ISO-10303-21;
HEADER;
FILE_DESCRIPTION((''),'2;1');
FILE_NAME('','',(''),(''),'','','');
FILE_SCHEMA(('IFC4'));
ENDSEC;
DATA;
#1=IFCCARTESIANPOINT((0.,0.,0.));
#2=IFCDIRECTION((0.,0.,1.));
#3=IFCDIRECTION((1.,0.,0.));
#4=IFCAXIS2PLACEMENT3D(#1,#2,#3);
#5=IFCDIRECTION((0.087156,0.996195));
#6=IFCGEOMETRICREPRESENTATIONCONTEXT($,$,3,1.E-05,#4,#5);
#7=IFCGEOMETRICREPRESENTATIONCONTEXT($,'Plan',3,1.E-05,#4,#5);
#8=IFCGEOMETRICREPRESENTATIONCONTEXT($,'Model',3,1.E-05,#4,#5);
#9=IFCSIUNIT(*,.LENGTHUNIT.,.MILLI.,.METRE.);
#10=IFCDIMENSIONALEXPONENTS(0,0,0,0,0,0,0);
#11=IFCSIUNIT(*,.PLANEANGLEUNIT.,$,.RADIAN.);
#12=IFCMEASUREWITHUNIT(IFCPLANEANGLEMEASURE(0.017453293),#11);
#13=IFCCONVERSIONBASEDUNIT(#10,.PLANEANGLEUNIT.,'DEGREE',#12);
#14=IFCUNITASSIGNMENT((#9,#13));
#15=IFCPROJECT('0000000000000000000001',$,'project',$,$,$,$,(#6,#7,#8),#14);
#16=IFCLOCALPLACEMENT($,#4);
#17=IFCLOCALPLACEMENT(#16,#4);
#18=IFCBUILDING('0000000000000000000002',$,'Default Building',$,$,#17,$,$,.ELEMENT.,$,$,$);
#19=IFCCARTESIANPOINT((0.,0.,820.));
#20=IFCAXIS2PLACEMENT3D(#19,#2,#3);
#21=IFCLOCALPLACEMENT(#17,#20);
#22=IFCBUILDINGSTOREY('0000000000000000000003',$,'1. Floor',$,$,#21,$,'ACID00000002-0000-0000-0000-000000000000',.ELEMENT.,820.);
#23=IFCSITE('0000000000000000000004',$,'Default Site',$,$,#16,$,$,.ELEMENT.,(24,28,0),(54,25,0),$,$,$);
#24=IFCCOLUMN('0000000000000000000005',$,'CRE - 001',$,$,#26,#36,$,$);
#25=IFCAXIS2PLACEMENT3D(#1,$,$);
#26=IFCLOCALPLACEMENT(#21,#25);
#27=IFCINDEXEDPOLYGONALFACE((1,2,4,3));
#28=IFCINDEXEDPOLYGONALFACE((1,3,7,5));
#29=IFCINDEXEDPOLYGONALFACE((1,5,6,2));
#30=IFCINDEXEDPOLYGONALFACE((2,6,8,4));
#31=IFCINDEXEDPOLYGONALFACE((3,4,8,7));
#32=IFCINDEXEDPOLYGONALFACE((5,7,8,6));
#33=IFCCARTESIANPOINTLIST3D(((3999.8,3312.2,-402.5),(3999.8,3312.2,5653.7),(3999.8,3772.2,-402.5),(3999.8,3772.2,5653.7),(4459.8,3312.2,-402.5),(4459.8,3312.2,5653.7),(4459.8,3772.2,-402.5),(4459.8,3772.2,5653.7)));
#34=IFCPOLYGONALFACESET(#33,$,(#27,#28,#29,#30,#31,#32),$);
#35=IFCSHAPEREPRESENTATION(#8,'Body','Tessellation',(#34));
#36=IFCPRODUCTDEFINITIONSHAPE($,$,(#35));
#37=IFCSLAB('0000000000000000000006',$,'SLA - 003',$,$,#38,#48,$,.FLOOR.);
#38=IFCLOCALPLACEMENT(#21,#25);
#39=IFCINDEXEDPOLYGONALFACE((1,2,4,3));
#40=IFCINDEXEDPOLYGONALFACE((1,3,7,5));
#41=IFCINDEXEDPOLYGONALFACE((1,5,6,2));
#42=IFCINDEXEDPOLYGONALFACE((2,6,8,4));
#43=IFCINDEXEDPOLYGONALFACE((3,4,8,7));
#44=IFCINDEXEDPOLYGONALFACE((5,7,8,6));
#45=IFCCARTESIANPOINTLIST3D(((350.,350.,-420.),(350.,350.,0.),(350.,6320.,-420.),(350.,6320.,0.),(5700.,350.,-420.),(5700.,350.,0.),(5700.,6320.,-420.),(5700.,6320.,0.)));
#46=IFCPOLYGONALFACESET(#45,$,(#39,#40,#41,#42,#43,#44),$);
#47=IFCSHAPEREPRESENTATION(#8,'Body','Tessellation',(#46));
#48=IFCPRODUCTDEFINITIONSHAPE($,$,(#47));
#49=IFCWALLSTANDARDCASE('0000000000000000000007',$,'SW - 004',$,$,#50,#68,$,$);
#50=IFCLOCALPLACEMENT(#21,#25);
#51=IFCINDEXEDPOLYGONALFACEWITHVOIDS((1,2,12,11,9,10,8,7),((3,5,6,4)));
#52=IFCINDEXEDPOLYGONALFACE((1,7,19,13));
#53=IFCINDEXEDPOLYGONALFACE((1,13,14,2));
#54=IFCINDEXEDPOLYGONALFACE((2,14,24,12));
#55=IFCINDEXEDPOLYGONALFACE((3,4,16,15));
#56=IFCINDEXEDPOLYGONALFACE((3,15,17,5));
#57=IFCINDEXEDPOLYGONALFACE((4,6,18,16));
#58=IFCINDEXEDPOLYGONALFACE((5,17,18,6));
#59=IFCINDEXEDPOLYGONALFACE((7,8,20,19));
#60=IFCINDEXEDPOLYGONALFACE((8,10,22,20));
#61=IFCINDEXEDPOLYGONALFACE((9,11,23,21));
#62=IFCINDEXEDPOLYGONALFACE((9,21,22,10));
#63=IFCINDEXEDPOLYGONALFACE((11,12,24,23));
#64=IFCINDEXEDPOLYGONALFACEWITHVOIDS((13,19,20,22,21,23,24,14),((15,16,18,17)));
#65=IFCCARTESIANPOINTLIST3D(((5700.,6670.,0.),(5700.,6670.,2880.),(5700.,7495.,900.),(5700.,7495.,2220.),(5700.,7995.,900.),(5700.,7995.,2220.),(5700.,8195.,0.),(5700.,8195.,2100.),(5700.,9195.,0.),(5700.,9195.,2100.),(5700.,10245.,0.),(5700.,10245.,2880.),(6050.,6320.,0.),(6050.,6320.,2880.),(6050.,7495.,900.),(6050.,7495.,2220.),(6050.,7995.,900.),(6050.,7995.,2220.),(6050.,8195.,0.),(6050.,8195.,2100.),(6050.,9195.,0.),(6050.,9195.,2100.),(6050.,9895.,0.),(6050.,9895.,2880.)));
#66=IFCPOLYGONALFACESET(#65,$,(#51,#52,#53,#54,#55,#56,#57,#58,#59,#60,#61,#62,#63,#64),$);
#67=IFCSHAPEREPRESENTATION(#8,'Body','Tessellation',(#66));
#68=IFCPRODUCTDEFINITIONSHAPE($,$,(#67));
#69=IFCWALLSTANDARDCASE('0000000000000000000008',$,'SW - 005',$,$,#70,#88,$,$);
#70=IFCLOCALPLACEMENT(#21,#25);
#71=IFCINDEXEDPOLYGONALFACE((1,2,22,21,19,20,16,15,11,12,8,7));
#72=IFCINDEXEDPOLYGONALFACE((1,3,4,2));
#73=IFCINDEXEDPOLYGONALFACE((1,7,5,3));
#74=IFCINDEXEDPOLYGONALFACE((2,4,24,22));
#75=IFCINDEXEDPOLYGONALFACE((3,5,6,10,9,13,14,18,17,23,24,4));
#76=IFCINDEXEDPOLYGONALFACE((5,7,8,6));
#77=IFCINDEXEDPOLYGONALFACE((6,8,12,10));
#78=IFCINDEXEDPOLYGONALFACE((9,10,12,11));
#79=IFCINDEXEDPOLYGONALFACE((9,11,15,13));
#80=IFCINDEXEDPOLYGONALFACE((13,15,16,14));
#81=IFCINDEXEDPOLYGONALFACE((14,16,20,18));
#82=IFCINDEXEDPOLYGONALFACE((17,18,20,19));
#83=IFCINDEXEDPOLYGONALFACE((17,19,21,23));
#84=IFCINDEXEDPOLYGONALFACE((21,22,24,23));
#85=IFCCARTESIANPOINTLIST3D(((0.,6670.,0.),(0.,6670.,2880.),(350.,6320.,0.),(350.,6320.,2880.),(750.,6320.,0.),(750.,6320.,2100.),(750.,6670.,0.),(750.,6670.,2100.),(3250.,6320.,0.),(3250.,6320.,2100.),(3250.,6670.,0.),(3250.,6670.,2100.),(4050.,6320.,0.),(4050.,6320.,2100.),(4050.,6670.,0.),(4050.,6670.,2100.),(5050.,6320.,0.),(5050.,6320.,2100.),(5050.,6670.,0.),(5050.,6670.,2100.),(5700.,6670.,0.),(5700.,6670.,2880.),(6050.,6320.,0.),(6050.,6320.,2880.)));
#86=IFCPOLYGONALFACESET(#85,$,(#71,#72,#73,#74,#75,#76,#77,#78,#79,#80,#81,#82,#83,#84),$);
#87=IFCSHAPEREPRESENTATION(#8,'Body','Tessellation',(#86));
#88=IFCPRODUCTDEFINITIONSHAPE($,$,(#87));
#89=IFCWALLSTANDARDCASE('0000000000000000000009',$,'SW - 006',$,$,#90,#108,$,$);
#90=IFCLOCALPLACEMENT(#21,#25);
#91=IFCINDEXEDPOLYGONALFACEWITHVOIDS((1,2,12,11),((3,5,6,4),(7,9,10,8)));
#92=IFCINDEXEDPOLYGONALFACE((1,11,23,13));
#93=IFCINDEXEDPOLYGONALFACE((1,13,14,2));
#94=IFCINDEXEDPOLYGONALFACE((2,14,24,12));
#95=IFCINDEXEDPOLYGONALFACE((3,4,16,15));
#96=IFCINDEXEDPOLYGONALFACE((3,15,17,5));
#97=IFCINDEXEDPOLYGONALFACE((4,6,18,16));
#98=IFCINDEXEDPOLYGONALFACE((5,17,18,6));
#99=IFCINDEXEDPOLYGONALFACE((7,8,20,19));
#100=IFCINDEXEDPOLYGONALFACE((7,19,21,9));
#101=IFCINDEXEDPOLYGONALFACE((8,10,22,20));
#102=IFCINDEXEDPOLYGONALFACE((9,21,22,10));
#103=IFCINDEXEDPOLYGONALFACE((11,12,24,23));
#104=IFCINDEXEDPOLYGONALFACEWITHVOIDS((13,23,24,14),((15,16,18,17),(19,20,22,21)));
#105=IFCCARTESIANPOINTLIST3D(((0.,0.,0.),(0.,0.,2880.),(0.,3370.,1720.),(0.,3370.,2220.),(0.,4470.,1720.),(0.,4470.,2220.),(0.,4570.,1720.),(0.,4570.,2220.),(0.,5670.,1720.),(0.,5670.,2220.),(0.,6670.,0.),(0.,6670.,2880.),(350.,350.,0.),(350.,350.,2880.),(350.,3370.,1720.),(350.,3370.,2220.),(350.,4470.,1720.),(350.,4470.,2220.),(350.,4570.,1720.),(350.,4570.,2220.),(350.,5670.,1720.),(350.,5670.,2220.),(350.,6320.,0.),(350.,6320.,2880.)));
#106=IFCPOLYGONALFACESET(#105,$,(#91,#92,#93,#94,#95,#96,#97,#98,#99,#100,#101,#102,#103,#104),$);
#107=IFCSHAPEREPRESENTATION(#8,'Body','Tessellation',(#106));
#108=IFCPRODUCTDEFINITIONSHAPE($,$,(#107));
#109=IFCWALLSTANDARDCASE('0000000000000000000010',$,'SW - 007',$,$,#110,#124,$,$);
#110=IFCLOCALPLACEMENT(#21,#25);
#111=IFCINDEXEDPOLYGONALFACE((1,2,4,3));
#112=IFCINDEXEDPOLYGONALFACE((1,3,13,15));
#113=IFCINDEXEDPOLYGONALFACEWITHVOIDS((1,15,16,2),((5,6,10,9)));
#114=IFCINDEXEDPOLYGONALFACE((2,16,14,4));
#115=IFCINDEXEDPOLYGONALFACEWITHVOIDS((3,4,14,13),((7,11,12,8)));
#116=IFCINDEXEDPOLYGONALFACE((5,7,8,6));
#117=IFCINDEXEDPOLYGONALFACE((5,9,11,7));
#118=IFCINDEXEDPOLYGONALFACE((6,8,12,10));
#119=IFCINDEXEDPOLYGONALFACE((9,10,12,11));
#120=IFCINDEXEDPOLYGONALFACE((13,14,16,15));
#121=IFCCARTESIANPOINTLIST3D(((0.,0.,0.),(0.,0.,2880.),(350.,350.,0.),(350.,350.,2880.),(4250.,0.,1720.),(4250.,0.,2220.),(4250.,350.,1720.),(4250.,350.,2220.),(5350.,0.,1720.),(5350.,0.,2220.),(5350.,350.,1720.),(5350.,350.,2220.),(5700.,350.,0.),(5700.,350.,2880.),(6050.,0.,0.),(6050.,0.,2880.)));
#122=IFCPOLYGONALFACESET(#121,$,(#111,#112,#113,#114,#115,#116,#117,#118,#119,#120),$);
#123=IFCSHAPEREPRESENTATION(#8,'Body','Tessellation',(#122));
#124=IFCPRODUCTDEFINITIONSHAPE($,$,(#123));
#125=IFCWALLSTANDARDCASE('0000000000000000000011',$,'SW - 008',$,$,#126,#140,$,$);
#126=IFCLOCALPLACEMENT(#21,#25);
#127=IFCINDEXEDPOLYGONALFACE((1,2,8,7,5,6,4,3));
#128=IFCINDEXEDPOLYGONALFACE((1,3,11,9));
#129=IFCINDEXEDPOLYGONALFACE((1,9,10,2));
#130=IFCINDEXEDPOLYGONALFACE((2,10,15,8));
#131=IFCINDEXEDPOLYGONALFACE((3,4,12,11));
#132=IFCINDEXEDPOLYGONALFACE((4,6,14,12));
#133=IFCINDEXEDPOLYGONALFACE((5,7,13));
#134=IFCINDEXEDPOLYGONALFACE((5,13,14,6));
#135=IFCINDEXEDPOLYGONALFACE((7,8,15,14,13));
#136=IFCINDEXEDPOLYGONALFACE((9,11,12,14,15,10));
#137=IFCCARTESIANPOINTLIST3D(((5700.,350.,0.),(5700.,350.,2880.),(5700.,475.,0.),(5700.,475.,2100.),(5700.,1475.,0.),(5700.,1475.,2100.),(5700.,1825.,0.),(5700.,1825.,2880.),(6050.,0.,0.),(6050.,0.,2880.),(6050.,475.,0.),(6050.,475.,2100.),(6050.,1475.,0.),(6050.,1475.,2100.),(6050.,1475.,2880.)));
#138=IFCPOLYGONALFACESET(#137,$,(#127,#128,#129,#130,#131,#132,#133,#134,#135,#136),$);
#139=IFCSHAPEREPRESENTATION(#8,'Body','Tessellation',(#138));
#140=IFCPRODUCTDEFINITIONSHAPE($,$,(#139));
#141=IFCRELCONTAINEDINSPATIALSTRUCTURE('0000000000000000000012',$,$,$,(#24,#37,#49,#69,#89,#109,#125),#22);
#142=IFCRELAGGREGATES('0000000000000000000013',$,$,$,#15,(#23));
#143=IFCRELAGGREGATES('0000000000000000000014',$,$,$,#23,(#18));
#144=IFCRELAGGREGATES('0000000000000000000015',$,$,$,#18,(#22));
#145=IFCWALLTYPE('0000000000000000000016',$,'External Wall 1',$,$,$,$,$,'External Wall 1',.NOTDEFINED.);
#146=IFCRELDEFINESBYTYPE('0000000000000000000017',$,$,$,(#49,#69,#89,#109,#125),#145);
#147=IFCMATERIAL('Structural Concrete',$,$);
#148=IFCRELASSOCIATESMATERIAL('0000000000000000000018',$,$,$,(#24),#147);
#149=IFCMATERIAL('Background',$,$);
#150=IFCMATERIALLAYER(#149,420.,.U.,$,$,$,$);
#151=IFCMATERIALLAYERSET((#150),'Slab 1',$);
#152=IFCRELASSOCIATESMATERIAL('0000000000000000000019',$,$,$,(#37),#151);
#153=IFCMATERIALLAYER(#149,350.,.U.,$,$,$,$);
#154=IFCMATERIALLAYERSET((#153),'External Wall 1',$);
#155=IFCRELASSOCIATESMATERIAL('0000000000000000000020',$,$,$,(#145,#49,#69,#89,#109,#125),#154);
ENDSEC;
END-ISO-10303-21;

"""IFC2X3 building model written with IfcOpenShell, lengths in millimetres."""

from ifc_helpers import new_model, entity, si_unit, converted_unit, direction, frame, frame_2d, origin_with_axes, origin_2d_with_axis, place, context, project, spatial, polyline, rectangle, outline, extrude, material, layer, layer_set, layer_usage, type_object, element, save


model = new_model("IFC2X3")

# Units and contexts
context_of_model = context(None, 3, precision=1e-05, world=origin_with_axes(), true_north=direction((0.087156, 0.996195)))
plan_context = context("Plan", 3, precision=1e-05, world=origin_with_axes(), true_north=direction((0.087156, 0.996195)))
model_context = context("Model", 3, precision=1e-05, world=origin_with_axes(), true_north=direction((0.087156, 0.996195)))
ifc_project = project(units=[si_unit("LENGTHUNIT", "METRE", prefix="MILLI"), converted_unit("PLANEANGLEUNIT", "DEGREE", entity("IfcPlaneAngleMeasure", 0.017453293), si_unit("PLANEANGLEUNIT", "RADIAN"), dimensions=[0, 0, 0, 0, 0, 0, 0])], contexts=[context_of_model, plan_context, model_context])

# Site, building, storey
site_placement = place(None, origin_with_axes())
site = spatial("IfcSite", under=ifc_project, at=site_placement, Name="Default Site", CompositionType="ELEMENT", RefLatitude=(24, 28, 0), RefLongitude=(54, 25, 0))
building_placement = place(site_placement, origin_with_axes())
building = spatial("IfcBuilding", under=site, at=building_placement, Name="Default Building", CompositionType="ELEMENT")
storey_placement = place(building_placement, frame((0.0, 0.0, 820.0), z_axis=(0.0, 0.0, 1.0), x_axis=(1.0, 0.0, 0.0)))
storey = spatial("IfcBuildingStorey", under=building, at=storey_placement, Name="1. Floor", LongName="ACID00000002-0000-0000-0000-000000000000", CompositionType="ELEMENT", Elevation=820.0)

# Column
ifc_material_1 = material(Name="Structural Concrete")
column_placement = place(storey_placement, frame((4229.8, 3542.2, -402.5), z_axis=(0.0, 0.0, 1.0), x_axis=(-1.0, 0.0, 0.0)))
element("IfcColumn", 1, at=column_placement, inside=storey, material=ifc_material_1, Name="CRE - 001", context=model_context, shape_type="SweptSolid", body=[
    extrude(rectangle(XDim=460.0, YDim=460.0, at=origin_2d_with_axis()), origin_with_axes(), (0.0, 0.0, 1.0), 6056.2),
])

# Slab
ifc_material_2 = material(Name="Background")
ifc_layer_1 = layer(ifc_material_2, 420.0, ventilated="UNKNOWN")
ifc_layer_set_1 = layer_set([ifc_layer_1], Name="Slab 1")
ifc_layer_usage_1 = layer_usage(ifc_layer_set_1, "AXIS3", "NEGATIVE", 420.0)
slab_placement = place(storey_placement, frame((350.0, 6320.0, -420.0), z_axis=(0.0, 0.0, 1.0), x_axis=(0.0, -1.0, 0.0)))
element("IfcSlab", 2, at=slab_placement, inside=storey, material=ifc_layer_usage_1, Name="SLA - 003", PredefinedType="FLOOR", context=model_context, shape_type="SweptSolid", body=[
    extrude(outline(polyline([(0.0, 0.0), (5970.0, 0.0), (5970.0, 5350.0), (0.0, 5350.0), (0.0, 0.0)])), origin_with_axes(), (0.0, 0.0, 1.0), 420.0),
])

# Walls, openings
ifc_layer_2 = layer(ifc_material_2, 350.0, ventilated="UNKNOWN")
ifc_layer_set_2 = layer_set([ifc_layer_2], Name="External Wall 1")
ifc_layer_usage_2 = layer_usage(ifc_layer_set_2, "AXIS2", "POSITIVE", 0.0)
wall_type_1 = type_object("IfcWallType", Name="External Wall 1", ElementType="External Wall 1", PredefinedType="NOTDEFINED", material=ifc_layer_set_2)
wall_1_placement = place(storey_placement, frame((5700.0, 10245.0, 0.0), z_axis=(0.0, 0.0, 1.0), x_axis=(0.0, -1.0, 0.0)))
wall_1 = element("IfcWallStandardCase", 3, at=wall_1_placement, inside=storey, type_object=wall_type_1, material=ifc_layer_usage_2, Name="SW - 004", context=model_context, shape_type="SweptSolid", body=[
    extrude(outline(polyline([(0.0, 0.0), (3575.0, 0.0), (3925.0, 350.0), (350.0, 350.0), (0.0, 0.0)])), origin_with_axes(), (0.0, 0.0, 1.0), 2880.0),
])
opening_1_placement = place(wall_1_placement, frame((1550.0, 0.0, 0.0), z_axis=(0.0, 0.0, 1.0), x_axis=(1.0, 0.0, 0.0)))
element("IfcOpeningElement", 4, at=opening_1_placement, cuts=wall_1, ObjectType="Opening", context=model_context, shape_type="SweptSolid", body=[
    extrude(rectangle(XDim=1000.0, YDim=2100.0, at=frame_2d((0.0, 1050.0), x_axis=(-1.0, 0.0))), frame((0.0, 0.0, 0.0), z_axis=(0.0, 1.0, 0.0), x_axis=(-1.0, 0.0, 0.0)), (0.0, 0.0, 1.0), 350.0),
])
opening_2_placement = place(wall_1_placement, frame((2500.0, 0.0, 900.0), z_axis=(0.0, 0.0, 1.0), x_axis=(1.0, 0.0, 0.0)))
element("IfcOpeningElement", 5, at=opening_2_placement, cuts=wall_1, ObjectType="Opening", context=model_context, shape_type="SweptSolid", body=[
    extrude(rectangle(XDim=500.0, YDim=1320.0, at=frame_2d((0.0, 660.0), x_axis=(-1.0, 0.0))), frame((0.0, 0.0, 0.0), z_axis=(0.0, 1.0, 0.0), x_axis=(-1.0, 0.0, 0.0)), (0.0, 0.0, 1.0), 350.0),
])
ifc_layer_usage_3 = layer_usage(ifc_layer_set_2, "AXIS2", "POSITIVE", 0.0)
wall_2_placement = place(storey_placement, frame((5700.0, 6670.0, 0.0), z_axis=(0.0, 0.0, 1.0), x_axis=(-1.0, 0.0, 0.0)))
wall_2 = element("IfcWallStandardCase", 6, at=wall_2_placement, inside=storey, type_object=wall_type_1, material=ifc_layer_usage_3, Name="SW - 005", context=model_context, shape_type="SweptSolid", body=[
    extrude(outline(polyline([(0.0, 0.0), (5700.0, 0.0), (5350.0, 350.0), (-350.0, 350.0), (0.0, 0.0)])), origin_with_axes(), (0.0, 0.0, 1.0), 2880.0),
])
opening_3_placement = place(wall_2_placement, frame((1150.0, 0.0, 0.0), z_axis=(0.0, 0.0, 1.0), x_axis=(1.0, 0.0, 0.0)))
element("IfcOpeningElement", 7, at=opening_3_placement, cuts=wall_2, ObjectType="Opening", context=model_context, shape_type="SweptSolid", body=[
    extrude(rectangle(XDim=1000.0, YDim=2100.0, at=frame_2d((0.0, 1050.0), x_axis=(-1.0, 0.0))), frame((0.0, 0.0, 0.0), z_axis=(0.0, 1.0, 0.0), x_axis=(-1.0, 0.0, 0.0)), (0.0, 0.0, 1.0), 350.0),
])
opening_4_placement = place(wall_2_placement, frame((3700.0, 0.0, 0.0), z_axis=(0.0, 0.0, 1.0), x_axis=(1.0, 0.0, 0.0)))
element("IfcOpeningElement", 8, at=opening_4_placement, cuts=wall_2, ObjectType="Opening", context=model_context, shape_type="SweptSolid", body=[
    extrude(rectangle(XDim=2500.0, YDim=2100.0, at=frame_2d((0.0, 1050.0), x_axis=(-1.0, 0.0))), frame((0.0, 0.0, 0.0), z_axis=(0.0, 1.0, 0.0), x_axis=(-1.0, 0.0, 0.0)), (0.0, 0.0, 1.0), 350.0),
])
ifc_layer_usage_4 = layer_usage(ifc_layer_set_2, "AXIS2", "POSITIVE", 0.0)
wall_3_placement = place(storey_placement, frame((0.0, 6670.0, 0.0), z_axis=(0.0, 0.0, 1.0), x_axis=(0.0, -1.0, 0.0)))
wall_3 = element("IfcWallStandardCase", 9, at=wall_3_placement, inside=storey, type_object=wall_type_1, material=ifc_layer_usage_4, Name="SW - 006", context=model_context, shape_type="SweptSolid", body=[
    extrude(outline(polyline([(0.0, 0.0), (6670.0, 0.0), (6320.0, 350.0), (350.0, 350.0), (0.0, 0.0)])), origin_with_axes(), (0.0, 0.0, 1.0), 2880.0),
])
opening_5_placement = place(wall_3_placement, frame((1550.0, 0.0, 1720.0), z_axis=(0.0, 0.0, 1.0), x_axis=(1.0, 0.0, 0.0)))
element("IfcOpeningElement", 10, at=opening_5_placement, cuts=wall_3, ObjectType="Opening", context=model_context, shape_type="SweptSolid", body=[
    extrude(rectangle(XDim=1100.0, YDim=500.0, at=frame_2d((0.0, 250.0), x_axis=(-1.0, 0.0))), frame((0.0, 0.0, 0.0), z_axis=(0.0, 1.0, 0.0), x_axis=(-1.0, 0.0, 0.0)), (0.0, 0.0, 1.0), 350.0),
])
opening_6_placement = place(wall_3_placement, frame((2750.0, 0.0, 1720.0), z_axis=(0.0, 0.0, 1.0), x_axis=(1.0, 0.0, 0.0)))
element("IfcOpeningElement", 11, at=opening_6_placement, cuts=wall_3, ObjectType="Opening", context=model_context, shape_type="SweptSolid", body=[
    extrude(rectangle(XDim=1100.0, YDim=500.0, at=frame_2d((0.0, 250.0), x_axis=(-1.0, 0.0))), frame((0.0, 0.0, 0.0), z_axis=(0.0, 1.0, 0.0), x_axis=(-1.0, 0.0, 0.0)), (0.0, 0.0, 1.0), 350.0),
])

# Walls, openings
ifc_layer_usage_5 = layer_usage(ifc_layer_set_2, "AXIS2", "POSITIVE", 0.0)
wall_4_placement = place(storey_placement, origin_with_axes())
wall_4 = element("IfcWallStandardCase", 12, at=wall_4_placement, inside=storey, type_object=wall_type_1, material=ifc_layer_usage_5, Name="SW - 007", context=model_context, shape_type="SweptSolid", body=[
    extrude(outline(polyline([(0.0, 0.0), (6050.0, 0.0), (5700.0, 350.0), (350.0, 350.0), (0.0, 0.0)])), origin_with_axes(), (0.0, 0.0, 1.0), 2880.0),
])
opening_7_placement = place(wall_4_placement, frame((4800.0, 0.0, 1720.0), z_axis=(0.0, 0.0, 1.0), x_axis=(1.0, 0.0, 0.0)))
element("IfcOpeningElement", 13, at=opening_7_placement, cuts=wall_4, ObjectType="Opening", context=model_context, shape_type="SweptSolid", body=[
    extrude(rectangle(XDim=1100.0, YDim=500.0, at=frame_2d((0.0, 250.0), x_axis=(1.0, 0.0))), frame((0.0, 0.0, 0.0), z_axis=(0.0, 1.0, 0.0), x_axis=(-1.0, 0.0, 0.0)), (0.0, 0.0, 1.0), 350.0),
])
ifc_layer_usage_6 = layer_usage(ifc_layer_set_2, "AXIS2", "POSITIVE", 0.0)
wall_5_placement = place(storey_placement, frame((6050.0, 0.0, 0.0), z_axis=(0.0, 0.0, 1.0), x_axis=(0.0, 1.0, 0.0)))
wall_5 = element("IfcWallStandardCase", 14, at=wall_5_placement, inside=storey, type_object=wall_type_1, material=ifc_layer_usage_6, Name="SW - 008", context=model_context, shape_type="SweptSolid", body=[
    extrude(outline(polyline([(0.0, 0.0), (1475.0, 0.0), (1825.0, 350.0), (350.0, 350.0), (0.0, 0.0)])), origin_with_axes(), (0.0, 0.0, 1.0), 2880.0),
])
opening_8_placement = place(wall_5_placement, frame((975.0, 0.0, 0.0), z_axis=(0.0, 0.0, 1.0), x_axis=(1.0, 0.0, 0.0)))
element("IfcOpeningElement", 15, at=opening_8_placement, cuts=wall_5, ObjectType="Opening", context=model_context, shape_type="SweptSolid", body=[
    extrude(outline(polyline([(-500.0, 0.0), (500.0, 0.0), (500.0, 2100.0), (-500.0, 2100.0), (-500.0, 0.0)])), frame((0.0, 0.0, 0.0), z_axis=(0.0, 1.0, 0.0), x_axis=(-1.0, 0.0, 0.0)), (0.0, 0.0, 1.0), 350.0),
])

save(model, "model.ifc")
